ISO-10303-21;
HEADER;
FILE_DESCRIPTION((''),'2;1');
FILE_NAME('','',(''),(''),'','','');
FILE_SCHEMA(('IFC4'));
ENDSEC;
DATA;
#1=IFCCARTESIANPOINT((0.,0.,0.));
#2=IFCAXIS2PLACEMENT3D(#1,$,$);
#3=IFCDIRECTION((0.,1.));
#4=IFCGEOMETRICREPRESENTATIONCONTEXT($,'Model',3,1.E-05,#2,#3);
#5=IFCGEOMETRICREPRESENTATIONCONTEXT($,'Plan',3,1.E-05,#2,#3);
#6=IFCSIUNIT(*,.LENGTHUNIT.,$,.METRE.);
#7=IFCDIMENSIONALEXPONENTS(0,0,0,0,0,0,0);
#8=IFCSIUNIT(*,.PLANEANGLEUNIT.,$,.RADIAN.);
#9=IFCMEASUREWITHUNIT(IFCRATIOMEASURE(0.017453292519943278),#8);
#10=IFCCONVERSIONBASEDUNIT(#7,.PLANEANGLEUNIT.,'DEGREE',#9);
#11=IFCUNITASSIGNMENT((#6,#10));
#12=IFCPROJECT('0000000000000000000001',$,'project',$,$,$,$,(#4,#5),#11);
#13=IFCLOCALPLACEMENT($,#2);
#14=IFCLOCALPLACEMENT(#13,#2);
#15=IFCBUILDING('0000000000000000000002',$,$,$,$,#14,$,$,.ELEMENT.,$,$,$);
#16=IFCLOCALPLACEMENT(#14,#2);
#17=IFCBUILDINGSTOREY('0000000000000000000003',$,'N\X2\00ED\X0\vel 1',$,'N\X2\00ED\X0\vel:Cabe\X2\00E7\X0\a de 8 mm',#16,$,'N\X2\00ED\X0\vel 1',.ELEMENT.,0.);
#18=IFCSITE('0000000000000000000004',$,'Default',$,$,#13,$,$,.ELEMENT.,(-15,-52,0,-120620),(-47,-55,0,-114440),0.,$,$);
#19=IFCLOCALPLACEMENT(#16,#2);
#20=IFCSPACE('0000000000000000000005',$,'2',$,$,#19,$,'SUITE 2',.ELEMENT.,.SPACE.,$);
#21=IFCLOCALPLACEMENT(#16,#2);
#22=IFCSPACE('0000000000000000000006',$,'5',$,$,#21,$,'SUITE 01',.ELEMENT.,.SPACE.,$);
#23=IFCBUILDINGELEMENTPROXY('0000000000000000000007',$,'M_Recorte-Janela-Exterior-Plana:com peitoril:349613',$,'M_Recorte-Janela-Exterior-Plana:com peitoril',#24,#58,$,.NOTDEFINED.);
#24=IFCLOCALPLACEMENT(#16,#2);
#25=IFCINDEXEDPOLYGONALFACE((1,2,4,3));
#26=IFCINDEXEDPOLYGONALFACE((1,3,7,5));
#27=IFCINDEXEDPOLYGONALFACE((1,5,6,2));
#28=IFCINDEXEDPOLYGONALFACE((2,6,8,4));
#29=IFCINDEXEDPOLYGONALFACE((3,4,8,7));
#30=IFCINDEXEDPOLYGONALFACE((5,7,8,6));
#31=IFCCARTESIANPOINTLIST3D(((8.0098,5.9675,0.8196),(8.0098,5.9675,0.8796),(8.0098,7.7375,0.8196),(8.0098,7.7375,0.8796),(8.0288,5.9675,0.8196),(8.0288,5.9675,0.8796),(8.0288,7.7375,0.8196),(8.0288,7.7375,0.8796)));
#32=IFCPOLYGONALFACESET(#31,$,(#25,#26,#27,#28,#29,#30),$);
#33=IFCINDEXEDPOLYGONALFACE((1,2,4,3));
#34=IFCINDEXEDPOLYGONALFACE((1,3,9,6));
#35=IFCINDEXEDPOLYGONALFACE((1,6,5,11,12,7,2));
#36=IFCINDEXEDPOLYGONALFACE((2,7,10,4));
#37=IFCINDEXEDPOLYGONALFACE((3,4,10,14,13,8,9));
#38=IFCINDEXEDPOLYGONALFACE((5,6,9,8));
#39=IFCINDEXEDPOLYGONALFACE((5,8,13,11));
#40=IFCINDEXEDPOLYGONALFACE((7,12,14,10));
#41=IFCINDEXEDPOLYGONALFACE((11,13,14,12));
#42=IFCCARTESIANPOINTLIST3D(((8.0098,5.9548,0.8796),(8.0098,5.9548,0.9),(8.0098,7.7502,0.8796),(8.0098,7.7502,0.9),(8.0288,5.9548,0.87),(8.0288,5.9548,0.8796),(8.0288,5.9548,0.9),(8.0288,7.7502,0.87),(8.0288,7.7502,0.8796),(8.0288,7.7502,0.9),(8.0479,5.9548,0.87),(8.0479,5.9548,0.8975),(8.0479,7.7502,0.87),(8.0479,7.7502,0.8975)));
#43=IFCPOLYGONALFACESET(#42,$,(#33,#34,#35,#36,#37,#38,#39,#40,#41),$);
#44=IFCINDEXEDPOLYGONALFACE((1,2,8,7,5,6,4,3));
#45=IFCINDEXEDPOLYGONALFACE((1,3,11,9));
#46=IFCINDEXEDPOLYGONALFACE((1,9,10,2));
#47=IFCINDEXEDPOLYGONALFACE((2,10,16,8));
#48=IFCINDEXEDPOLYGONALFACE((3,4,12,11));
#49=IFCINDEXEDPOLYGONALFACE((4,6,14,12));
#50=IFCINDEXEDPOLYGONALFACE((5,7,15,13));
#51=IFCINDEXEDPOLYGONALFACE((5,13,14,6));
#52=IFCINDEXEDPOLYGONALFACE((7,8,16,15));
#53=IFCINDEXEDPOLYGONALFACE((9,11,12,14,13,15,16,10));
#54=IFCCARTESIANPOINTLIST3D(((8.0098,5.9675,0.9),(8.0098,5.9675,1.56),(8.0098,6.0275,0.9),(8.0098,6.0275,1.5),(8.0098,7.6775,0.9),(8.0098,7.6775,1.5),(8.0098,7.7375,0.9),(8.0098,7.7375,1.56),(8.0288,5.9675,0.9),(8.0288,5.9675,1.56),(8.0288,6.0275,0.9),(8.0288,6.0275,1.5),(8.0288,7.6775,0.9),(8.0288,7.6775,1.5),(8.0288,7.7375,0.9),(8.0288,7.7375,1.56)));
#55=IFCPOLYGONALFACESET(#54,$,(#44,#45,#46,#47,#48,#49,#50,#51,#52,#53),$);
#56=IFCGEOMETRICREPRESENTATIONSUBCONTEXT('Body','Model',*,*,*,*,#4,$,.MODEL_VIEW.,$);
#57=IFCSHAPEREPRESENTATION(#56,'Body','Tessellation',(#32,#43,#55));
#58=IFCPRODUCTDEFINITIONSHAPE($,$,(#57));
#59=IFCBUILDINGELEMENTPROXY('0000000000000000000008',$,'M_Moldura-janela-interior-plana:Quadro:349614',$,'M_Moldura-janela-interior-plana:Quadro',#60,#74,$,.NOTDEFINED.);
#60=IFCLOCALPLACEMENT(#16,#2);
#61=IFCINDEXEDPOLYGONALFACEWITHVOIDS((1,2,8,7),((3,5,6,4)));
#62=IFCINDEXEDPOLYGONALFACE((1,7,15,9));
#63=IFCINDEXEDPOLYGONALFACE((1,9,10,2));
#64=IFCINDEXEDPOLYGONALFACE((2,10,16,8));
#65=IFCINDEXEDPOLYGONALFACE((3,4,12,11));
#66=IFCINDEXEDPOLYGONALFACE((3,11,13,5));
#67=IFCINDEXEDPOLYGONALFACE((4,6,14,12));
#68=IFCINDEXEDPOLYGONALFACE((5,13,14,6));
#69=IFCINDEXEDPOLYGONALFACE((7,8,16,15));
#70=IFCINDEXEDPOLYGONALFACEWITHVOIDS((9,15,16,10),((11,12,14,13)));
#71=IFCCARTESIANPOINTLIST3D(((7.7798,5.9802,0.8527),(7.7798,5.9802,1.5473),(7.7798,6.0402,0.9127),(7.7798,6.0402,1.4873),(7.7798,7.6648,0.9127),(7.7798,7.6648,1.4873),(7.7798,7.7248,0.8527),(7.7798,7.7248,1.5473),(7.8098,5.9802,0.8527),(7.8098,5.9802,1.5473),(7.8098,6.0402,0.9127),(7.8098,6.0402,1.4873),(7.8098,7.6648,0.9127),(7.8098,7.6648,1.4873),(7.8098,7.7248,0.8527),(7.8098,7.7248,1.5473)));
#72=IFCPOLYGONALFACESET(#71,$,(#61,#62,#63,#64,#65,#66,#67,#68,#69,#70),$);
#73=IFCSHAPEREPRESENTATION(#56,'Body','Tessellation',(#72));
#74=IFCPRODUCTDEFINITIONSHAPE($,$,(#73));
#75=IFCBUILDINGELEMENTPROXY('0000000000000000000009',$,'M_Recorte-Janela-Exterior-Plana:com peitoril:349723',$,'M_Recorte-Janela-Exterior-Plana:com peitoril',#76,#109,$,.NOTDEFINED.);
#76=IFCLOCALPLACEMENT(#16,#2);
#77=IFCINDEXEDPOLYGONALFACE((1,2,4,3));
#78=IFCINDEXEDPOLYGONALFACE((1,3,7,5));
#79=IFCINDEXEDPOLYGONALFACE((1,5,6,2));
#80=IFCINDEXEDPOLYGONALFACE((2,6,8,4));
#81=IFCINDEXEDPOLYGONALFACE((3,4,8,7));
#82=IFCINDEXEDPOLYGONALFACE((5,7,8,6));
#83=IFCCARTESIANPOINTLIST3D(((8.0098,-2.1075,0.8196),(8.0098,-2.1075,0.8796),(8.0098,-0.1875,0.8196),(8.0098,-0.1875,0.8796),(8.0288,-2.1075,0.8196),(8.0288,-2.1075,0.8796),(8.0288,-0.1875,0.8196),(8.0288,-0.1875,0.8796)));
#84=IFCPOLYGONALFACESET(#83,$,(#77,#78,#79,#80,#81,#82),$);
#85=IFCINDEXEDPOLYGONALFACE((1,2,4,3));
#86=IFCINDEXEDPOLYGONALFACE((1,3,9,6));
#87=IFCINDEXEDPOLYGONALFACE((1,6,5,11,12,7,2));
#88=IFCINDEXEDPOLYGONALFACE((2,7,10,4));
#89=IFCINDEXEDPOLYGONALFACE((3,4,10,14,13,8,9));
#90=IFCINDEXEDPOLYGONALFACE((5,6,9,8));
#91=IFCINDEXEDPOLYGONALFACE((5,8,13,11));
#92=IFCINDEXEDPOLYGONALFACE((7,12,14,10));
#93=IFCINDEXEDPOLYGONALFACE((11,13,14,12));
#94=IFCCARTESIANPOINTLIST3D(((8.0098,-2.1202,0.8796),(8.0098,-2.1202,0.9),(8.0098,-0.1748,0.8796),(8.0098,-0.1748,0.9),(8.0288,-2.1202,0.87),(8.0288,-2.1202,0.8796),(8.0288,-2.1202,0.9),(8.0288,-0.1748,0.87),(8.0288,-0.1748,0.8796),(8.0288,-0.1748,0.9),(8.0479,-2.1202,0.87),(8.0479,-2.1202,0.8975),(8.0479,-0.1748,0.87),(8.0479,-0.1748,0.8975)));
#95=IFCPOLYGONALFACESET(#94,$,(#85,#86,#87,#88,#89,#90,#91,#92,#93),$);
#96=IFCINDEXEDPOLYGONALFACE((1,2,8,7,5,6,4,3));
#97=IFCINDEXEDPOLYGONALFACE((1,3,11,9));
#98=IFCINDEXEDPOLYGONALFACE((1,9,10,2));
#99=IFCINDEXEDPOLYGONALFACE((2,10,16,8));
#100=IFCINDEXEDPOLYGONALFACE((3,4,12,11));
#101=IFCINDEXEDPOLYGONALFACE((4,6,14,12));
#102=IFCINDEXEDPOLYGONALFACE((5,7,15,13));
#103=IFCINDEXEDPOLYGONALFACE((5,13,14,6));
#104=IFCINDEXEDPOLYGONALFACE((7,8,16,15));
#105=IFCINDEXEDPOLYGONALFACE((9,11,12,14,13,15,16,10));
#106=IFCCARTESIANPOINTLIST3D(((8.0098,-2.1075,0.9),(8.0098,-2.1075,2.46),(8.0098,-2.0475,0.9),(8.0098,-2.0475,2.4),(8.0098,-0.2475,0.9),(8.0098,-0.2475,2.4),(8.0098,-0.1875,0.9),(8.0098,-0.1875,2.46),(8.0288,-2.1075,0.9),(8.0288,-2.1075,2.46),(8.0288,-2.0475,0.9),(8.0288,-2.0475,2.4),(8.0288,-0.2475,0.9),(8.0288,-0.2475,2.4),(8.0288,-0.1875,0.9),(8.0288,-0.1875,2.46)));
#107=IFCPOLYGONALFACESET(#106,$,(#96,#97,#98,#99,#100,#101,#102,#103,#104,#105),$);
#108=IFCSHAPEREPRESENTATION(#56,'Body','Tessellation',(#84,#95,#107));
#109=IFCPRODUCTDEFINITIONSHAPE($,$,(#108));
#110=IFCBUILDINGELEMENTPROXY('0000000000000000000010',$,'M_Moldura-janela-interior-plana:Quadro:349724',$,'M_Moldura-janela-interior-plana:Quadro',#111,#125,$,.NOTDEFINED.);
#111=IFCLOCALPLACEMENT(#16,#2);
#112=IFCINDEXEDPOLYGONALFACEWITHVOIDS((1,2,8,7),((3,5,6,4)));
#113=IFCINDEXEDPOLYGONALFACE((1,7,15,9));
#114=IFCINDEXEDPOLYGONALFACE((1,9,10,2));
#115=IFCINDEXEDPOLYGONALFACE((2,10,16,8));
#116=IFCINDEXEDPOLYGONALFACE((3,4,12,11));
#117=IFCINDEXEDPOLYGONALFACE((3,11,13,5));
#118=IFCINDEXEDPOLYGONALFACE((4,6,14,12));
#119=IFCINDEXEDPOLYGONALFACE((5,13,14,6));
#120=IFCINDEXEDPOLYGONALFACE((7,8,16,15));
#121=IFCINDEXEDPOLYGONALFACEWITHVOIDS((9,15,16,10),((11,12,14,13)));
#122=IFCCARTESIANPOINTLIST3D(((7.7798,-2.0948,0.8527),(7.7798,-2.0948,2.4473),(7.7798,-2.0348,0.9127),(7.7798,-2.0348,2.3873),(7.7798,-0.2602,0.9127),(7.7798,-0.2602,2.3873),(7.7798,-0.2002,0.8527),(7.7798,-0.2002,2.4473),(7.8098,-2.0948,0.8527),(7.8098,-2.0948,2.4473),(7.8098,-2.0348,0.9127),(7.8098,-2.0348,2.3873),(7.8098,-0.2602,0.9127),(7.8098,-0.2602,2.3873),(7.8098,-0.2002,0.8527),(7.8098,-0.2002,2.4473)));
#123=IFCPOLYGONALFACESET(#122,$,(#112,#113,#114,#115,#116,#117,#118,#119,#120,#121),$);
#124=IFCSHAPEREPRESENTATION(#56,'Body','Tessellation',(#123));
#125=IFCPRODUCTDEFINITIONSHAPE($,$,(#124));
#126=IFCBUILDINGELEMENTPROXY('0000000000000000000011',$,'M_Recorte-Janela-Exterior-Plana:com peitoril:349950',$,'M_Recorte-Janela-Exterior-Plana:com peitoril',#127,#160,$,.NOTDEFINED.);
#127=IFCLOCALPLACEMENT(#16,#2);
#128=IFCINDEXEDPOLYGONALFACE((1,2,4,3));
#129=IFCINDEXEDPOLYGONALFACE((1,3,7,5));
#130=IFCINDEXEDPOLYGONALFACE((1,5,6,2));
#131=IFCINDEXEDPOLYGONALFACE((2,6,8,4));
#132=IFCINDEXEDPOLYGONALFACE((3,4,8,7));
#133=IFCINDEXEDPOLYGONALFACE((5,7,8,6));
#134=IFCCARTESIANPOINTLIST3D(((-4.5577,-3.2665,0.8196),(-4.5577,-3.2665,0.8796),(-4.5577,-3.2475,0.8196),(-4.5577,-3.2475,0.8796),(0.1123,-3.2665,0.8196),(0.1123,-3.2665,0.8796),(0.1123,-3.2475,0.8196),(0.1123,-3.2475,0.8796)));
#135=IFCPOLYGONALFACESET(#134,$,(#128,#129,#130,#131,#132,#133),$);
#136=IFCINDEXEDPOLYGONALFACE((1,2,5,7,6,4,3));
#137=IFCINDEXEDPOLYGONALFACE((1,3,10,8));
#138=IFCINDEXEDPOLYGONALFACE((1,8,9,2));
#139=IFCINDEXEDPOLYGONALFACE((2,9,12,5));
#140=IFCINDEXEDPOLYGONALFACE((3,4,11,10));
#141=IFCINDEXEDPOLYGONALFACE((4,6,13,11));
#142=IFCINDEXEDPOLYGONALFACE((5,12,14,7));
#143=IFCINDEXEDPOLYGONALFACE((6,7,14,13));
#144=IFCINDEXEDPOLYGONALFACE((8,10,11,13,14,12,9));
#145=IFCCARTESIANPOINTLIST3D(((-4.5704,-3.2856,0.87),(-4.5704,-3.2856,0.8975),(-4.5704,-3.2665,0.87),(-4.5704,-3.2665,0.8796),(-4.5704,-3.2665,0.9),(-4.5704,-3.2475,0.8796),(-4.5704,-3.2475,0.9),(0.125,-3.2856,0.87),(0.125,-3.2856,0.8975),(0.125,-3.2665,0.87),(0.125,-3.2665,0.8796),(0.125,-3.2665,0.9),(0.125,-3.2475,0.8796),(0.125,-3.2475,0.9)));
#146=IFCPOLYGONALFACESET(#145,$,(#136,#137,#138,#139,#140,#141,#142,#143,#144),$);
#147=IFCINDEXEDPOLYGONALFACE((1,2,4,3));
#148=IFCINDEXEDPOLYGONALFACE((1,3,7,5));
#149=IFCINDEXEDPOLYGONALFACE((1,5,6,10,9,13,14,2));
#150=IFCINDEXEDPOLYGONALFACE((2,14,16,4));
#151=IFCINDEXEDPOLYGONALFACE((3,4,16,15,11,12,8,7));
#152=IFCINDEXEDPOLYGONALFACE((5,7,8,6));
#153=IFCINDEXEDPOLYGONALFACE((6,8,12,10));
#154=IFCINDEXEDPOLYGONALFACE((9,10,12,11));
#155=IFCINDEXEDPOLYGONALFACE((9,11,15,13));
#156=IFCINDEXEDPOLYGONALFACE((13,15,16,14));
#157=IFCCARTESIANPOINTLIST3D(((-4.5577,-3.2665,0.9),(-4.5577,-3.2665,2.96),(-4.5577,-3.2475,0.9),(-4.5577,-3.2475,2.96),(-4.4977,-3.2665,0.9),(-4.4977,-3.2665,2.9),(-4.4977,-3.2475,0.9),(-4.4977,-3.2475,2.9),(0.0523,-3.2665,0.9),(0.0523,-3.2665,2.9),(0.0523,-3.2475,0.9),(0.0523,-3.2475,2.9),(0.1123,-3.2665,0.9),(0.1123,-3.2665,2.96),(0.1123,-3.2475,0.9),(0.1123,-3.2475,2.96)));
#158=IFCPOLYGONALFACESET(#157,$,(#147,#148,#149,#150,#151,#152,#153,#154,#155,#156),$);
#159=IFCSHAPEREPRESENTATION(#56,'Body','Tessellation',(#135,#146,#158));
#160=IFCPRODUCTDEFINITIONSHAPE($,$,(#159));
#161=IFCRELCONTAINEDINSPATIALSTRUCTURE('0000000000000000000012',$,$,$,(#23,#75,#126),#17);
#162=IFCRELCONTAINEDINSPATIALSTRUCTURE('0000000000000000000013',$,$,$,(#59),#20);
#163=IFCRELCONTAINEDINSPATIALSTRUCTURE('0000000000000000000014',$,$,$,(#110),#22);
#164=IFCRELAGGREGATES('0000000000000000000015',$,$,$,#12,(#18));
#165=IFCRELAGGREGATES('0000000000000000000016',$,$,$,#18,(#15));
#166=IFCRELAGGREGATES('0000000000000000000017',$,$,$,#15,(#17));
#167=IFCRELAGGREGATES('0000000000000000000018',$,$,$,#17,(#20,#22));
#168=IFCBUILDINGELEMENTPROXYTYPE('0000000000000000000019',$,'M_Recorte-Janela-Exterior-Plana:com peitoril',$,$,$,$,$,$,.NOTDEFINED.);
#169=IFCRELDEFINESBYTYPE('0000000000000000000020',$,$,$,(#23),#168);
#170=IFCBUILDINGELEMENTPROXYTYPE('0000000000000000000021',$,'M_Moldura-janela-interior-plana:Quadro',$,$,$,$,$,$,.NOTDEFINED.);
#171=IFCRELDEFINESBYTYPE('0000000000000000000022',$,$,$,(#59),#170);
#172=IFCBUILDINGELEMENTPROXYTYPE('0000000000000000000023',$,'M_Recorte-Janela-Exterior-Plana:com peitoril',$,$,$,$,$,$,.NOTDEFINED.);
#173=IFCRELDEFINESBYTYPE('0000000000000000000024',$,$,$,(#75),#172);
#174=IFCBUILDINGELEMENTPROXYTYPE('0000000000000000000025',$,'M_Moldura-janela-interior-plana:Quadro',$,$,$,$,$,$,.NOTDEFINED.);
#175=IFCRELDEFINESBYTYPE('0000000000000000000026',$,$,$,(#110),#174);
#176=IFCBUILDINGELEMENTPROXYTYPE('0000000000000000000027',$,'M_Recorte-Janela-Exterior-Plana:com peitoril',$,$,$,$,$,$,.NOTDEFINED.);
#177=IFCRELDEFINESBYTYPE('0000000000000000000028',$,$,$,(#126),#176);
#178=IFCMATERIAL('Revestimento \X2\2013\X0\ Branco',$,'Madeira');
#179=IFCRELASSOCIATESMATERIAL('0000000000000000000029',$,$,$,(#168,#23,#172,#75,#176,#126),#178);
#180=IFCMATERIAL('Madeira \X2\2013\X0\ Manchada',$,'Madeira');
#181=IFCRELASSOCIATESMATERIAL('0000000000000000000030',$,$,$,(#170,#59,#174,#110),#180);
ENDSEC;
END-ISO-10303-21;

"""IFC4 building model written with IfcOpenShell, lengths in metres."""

from ifc_helpers import new_model, entity, si_unit, converted_unit, direction, frame, origin, place, context, subcontext, project, spatial, indexed_curve, outline, extrude, source, transform, mapped, material, type_object, type_shapes, element, save


model = new_model("IFC4")

# Units and contexts
model_context = context("Model", 3, precision=1e-05, world=origin(), true_north=direction((0.0, 1.0)))
plan_context = context("Plan", 3, precision=1e-05, world=origin(), true_north=direction((0.0, 1.0)))
body_context = subcontext(model_context, "Body", "Model", "MODEL_VIEW")
ifc_project = project(units=[si_unit("LENGTHUNIT", "METRE"), converted_unit("PLANEANGLEUNIT", "DEGREE", entity("IfcRatioMeasure", 0.017453292519943278), si_unit("PLANEANGLEUNIT", "RADIAN"), dimensions=[0, 0, 0, 0, 0, 0, 0])], contexts=[model_context, plan_context])

# Site, building, storey
site_placement = place(None, origin())
site = spatial("IfcSite", under=ifc_project, at=site_placement, Name="Default", CompositionType="ELEMENT", RefLatitude=(-15, -52, 0, -120620), RefLongitude=(-47, -55, 0, -114440), RefElevation=0.0)
building_placement = place(site_placement, origin())
building = spatial("IfcBuilding", under=site, at=building_placement, CompositionType="ELEMENT")
storey_placement = place(building_placement, origin())
storey = spatial("IfcBuildingStorey", under=building, at=storey_placement, Name="Nível 1", ObjectType="Nível:Cabeça de 8 mm", LongName="Nível 1", CompositionType="ELEMENT", Elevation=0.0)

# Shared definitions
ifc_material_1 = material(Name="Revestimento – Branco", Category="Madeira")

# Building element proxy
ifc_material_2 = material(Name="Madeira – Manchada", Category="Madeira")
building_element_proxy_type_1 = type_object("IfcBuildingElementProxyType", Name="M_Recorte-Janela-Exterior-Plana:com peitoril", PredefinedType="NOTDEFINED", material=ifc_material_1)
shared_shape_1 = source(origin(), body_context, "Body", "SweptSolid", [
    extrude(outline(indexed_curve([(-0.885, -0.03), (0.885, -0.03), (0.885, 0.03), (-0.885, 0.03), (-0.885, -0.03)], self_intersect=False)), frame((0.0, -0.6504, 0.0), z_axis=(0.0, 0.0, 1.0), x_axis=(-1.0, 0.0, 0.0)), (0.0, 0.0, 1.0), 0.019),
    extrude(outline(indexed_curve([(-0.019, -0.0152), (0.0, -0.0152), (0.0, -0.0057), (0.019, -0.0057), (0.019, 0.0148), (0.0, 0.0148), (-0.019, 0.0123), (-0.019, -0.0152)], self_intersect=False)), frame((-0.8977, -0.6148, 0.019), z_axis=(1.0, 0.0, 0.0), x_axis=(0.0, 0.0, -1.0)), (0.0, 0.0, 1.0), 1.7954),
    extrude(outline(indexed_curve([(-0.345, -0.885), (0.315, -0.885), (0.315, -0.825), (-0.285, -0.825), (-0.285, 0.825), (0.315, 0.825), (0.315, 0.885), (-0.345, 0.885), (-0.345, -0.885)], self_intersect=False)), frame((0.0, -0.285, 0.0), z_axis=(0.0, 0.0, 1.0), x_axis=(0.0, -1.0, 0.0)), (0.0, 0.0, 1.0), 0.019),
])
type_shapes(building_element_proxy_type_1, [shared_shape_1])
proxy_1_placement = place(storey_placement, frame((8.0098, 6.8525, 1.5), z_axis=(1.0, 0.0, 0.0), x_axis=(0.0, 1.0, 0.0)))
element("IfcBuildingElementProxy", 1, at=proxy_1_placement, inside=storey, type_object=building_element_proxy_type_1, material=ifc_material_1, Name="M_Recorte-Janela-Exterior-Plana:com peitoril:349613", ObjectType="M_Recorte-Janela-Exterior-Plana:com peitoril", PredefinedType="NOTDEFINED", context=body_context, shape_type="MappedRepresentation", body=[
    mapped(shared_shape_1, transform((0.0, 0.0, 0.0), scale=1.0)),
])

# Shared definitions
space_1_placement = place(storey_placement, origin())
space_1 = spatial("IfcSpace", under=storey, at=space_1_placement, Name="2", LongName="SUITE 2", CompositionType="ELEMENT", PredefinedType="SPACE")

# Building element proxies
building_element_proxy_type_2 = type_object("IfcBuildingElementProxyType", Name="M_Moldura-janela-interior-plana:Quadro", PredefinedType="NOTDEFINED", material=ifc_material_2)
shared_shape_2 = source(origin(), body_context, "Body", "SweptSolid", [
    extrude(outline(indexed_curve([(-0.8723, -0.3473), (0.8723, -0.3473), (0.8723, 0.3473), (-0.8723, 0.3473), (-0.8723, -0.3473)], self_intersect=False), holes=[indexed_curve([(-0.8123, -0.2873), (-0.8123, 0.2873), (0.8123, 0.2873), (0.8123, -0.2873), (-0.8123, -0.2873)], self_intersect=False)]), frame((0.0, -0.3, 0.0), z_axis=(0.0, 0.0, 1.0), x_axis=(-1.0, 0.0, 0.0)), (0.0, 0.0, 1.0), 0.03),
])
type_shapes(building_element_proxy_type_2, [shared_shape_2])
proxy_2_placement = place(space_1_placement, frame((7.8098, 6.8525, 1.5), z_axis=(-1.0, 0.0, 0.0), x_axis=(0.0, -1.0, 0.0)))
element("IfcBuildingElementProxy", 2, at=proxy_2_placement, inside=space_1, type_object=building_element_proxy_type_2, material=ifc_material_2, Name="M_Moldura-janela-interior-plana:Quadro:349614", ObjectType="M_Moldura-janela-interior-plana:Quadro", PredefinedType="NOTDEFINED", context=body_context, shape_type="MappedRepresentation", body=[
    mapped(shared_shape_2, transform((0.0, 0.0, 0.0), scale=1.0)),
])
building_element_proxy_type_3 = type_object("IfcBuildingElementProxyType", Name="M_Recorte-Janela-Exterior-Plana:com peitoril", PredefinedType="NOTDEFINED", material=ifc_material_1)
shared_shape_3 = source(origin(), body_context, "Body", "SweptSolid", [
    extrude(outline(indexed_curve([(-0.96, -0.03), (0.96, -0.03), (0.96, 0.03), (-0.96, 0.03), (-0.96, -0.03)], self_intersect=False)), frame((0.0, -1.5504, 0.0), z_axis=(0.0, 0.0, 1.0), x_axis=(-1.0, 0.0, 0.0)), (0.0, 0.0, 1.0), 0.019),
    extrude(outline(indexed_curve([(-0.019, -0.0152), (0.0, -0.0152), (0.0, -0.0057), (0.019, -0.0057), (0.019, 0.0148), (0.0, 0.0148), (-0.019, 0.0123), (-0.019, -0.0152)], self_intersect=False)), frame((-0.9727, -1.5148, 0.019), z_axis=(1.0, 0.0, 0.0), x_axis=(0.0, 0.0, -1.0)), (0.0, 0.0, 1.0), 1.9454),
    extrude(outline(indexed_curve([(-0.795, -0.96), (0.765, -0.96), (0.765, -0.9), (-0.735, -0.9), (-0.735, 0.9), (0.765, 0.9), (0.765, 0.96), (-0.795, 0.96), (-0.795, -0.96)], self_intersect=False)), frame((0.0, -0.735, 0.0), z_axis=(0.0, 0.0, 1.0), x_axis=(0.0, -1.0, 0.0)), (0.0, 0.0, 1.0), 0.019),
])
type_shapes(building_element_proxy_type_3, [shared_shape_3])
proxy_3_placement = place(storey_placement, frame((8.0098, -1.1475, 2.4), z_axis=(1.0, 0.0, 0.0), x_axis=(0.0, 1.0, 0.0)))
element("IfcBuildingElementProxy", 3, at=proxy_3_placement, inside=storey, type_object=building_element_proxy_type_3, material=ifc_material_1, Name="M_Recorte-Janela-Exterior-Plana:com peitoril:349723", ObjectType="M_Recorte-Janela-Exterior-Plana:com peitoril", PredefinedType="NOTDEFINED", context=body_context, shape_type="MappedRepresentation", body=[
    mapped(shared_shape_3, transform((0.0, 0.0, 0.0), scale=1.0)),
])

# Shared definitions
space_2_placement = place(storey_placement, origin())
space_2 = spatial("IfcSpace", under=storey, at=space_2_placement, Name="5", LongName="SUITE 01", CompositionType="ELEMENT", PredefinedType="SPACE")

# Building element proxies
building_element_proxy_type_4 = type_object("IfcBuildingElementProxyType", Name="M_Moldura-janela-interior-plana:Quadro", PredefinedType="NOTDEFINED", material=ifc_material_2)
shared_shape_4 = source(origin(), body_context, "Body", "SweptSolid", [
    extrude(outline(indexed_curve([(-0.9473, -0.7973), (0.9473, -0.7973), (0.9473, 0.7973), (-0.9473, 0.7973), (-0.9473, -0.7973)], self_intersect=False), holes=[indexed_curve([(-0.8873, -0.7373), (-0.8873, 0.7373), (0.8873, 0.7373), (0.8873, -0.7373), (-0.8873, -0.7373)], self_intersect=False)]), frame((0.0, -0.75, 0.0), z_axis=(0.0, 0.0, 1.0), x_axis=(-1.0, 0.0, 0.0)), (0.0, 0.0, 1.0), 0.03),
])
type_shapes(building_element_proxy_type_4, [shared_shape_4])
proxy_4_placement = place(space_2_placement, frame((7.8098, -1.1475, 2.4), z_axis=(-1.0, 0.0, 0.0), x_axis=(0.0, -1.0, 0.0)))
element("IfcBuildingElementProxy", 4, at=proxy_4_placement, inside=space_2, type_object=building_element_proxy_type_4, material=ifc_material_2, Name="M_Moldura-janela-interior-plana:Quadro:349724", ObjectType="M_Moldura-janela-interior-plana:Quadro", PredefinedType="NOTDEFINED", context=body_context, shape_type="MappedRepresentation", body=[
    mapped(shared_shape_4, transform((0.0, 0.0, 0.0), scale=1.0)),
])
building_element_proxy_type_5 = type_object("IfcBuildingElementProxyType", Name="M_Recorte-Janela-Exterior-Plana:com peitoril", PredefinedType="NOTDEFINED", material=ifc_material_1)
shared_shape_5 = source(origin(), body_context, "Body", "SweptSolid", [
    extrude(outline(indexed_curve([(-2.335, -0.03), (2.335, -0.03), (2.335, 0.03), (-2.335, 0.03), (-2.335, -0.03)], self_intersect=False)), frame((0.0, -2.0504, 0.0), z_axis=(0.0, 0.0, 1.0), x_axis=(-1.0, 0.0, 0.0)), (0.0, 0.0, 1.0), 0.019),
    extrude(outline(indexed_curve([(-0.019, -0.0152), (0.0, -0.0152), (0.0, -0.0057), (0.019, -0.0057), (0.019, 0.0148), (0.0, 0.0148), (-0.019, 0.0123), (-0.019, -0.0152)], self_intersect=False)), frame((-2.3477, -2.0148, 0.019), z_axis=(1.0, 0.0, 0.0), x_axis=(0.0, 0.0, -1.0)), (0.0, 0.0, 1.0), 4.6954),
    extrude(outline(indexed_curve([(-1.045, -2.335), (1.015, -2.335), (1.015, -2.275), (-0.985, -2.275), (-0.985, 2.275), (1.015, 2.275), (1.015, 2.335), (-1.045, 2.335), (-1.045, -2.335)], self_intersect=False)), frame((0.0, -0.985, 0.0), z_axis=(0.0, 0.0, 1.0), x_axis=(0.0, -1.0, 0.0)), (0.0, 0.0, 1.0), 0.019),
])
type_shapes(building_element_proxy_type_5, [shared_shape_5])
proxy_5_placement = place(storey_placement, frame((-2.2227, -3.2475, 2.9), z_axis=(0.0, -1.0, 0.0), x_axis=(1.0, 0.0, 0.0)))
element("IfcBuildingElementProxy", 5, at=proxy_5_placement, inside=storey, type_object=building_element_proxy_type_5, material=ifc_material_1, Name="M_Recorte-Janela-Exterior-Plana:com peitoril:349950", ObjectType="M_Recorte-Janela-Exterior-Plana:com peitoril", PredefinedType="NOTDEFINED", context=body_context, shape_type="MappedRepresentation", body=[
    mapped(shared_shape_5, transform((0.0, 0.0, 0.0), scale=1.0)),
])

save(model, "model.ifc")
